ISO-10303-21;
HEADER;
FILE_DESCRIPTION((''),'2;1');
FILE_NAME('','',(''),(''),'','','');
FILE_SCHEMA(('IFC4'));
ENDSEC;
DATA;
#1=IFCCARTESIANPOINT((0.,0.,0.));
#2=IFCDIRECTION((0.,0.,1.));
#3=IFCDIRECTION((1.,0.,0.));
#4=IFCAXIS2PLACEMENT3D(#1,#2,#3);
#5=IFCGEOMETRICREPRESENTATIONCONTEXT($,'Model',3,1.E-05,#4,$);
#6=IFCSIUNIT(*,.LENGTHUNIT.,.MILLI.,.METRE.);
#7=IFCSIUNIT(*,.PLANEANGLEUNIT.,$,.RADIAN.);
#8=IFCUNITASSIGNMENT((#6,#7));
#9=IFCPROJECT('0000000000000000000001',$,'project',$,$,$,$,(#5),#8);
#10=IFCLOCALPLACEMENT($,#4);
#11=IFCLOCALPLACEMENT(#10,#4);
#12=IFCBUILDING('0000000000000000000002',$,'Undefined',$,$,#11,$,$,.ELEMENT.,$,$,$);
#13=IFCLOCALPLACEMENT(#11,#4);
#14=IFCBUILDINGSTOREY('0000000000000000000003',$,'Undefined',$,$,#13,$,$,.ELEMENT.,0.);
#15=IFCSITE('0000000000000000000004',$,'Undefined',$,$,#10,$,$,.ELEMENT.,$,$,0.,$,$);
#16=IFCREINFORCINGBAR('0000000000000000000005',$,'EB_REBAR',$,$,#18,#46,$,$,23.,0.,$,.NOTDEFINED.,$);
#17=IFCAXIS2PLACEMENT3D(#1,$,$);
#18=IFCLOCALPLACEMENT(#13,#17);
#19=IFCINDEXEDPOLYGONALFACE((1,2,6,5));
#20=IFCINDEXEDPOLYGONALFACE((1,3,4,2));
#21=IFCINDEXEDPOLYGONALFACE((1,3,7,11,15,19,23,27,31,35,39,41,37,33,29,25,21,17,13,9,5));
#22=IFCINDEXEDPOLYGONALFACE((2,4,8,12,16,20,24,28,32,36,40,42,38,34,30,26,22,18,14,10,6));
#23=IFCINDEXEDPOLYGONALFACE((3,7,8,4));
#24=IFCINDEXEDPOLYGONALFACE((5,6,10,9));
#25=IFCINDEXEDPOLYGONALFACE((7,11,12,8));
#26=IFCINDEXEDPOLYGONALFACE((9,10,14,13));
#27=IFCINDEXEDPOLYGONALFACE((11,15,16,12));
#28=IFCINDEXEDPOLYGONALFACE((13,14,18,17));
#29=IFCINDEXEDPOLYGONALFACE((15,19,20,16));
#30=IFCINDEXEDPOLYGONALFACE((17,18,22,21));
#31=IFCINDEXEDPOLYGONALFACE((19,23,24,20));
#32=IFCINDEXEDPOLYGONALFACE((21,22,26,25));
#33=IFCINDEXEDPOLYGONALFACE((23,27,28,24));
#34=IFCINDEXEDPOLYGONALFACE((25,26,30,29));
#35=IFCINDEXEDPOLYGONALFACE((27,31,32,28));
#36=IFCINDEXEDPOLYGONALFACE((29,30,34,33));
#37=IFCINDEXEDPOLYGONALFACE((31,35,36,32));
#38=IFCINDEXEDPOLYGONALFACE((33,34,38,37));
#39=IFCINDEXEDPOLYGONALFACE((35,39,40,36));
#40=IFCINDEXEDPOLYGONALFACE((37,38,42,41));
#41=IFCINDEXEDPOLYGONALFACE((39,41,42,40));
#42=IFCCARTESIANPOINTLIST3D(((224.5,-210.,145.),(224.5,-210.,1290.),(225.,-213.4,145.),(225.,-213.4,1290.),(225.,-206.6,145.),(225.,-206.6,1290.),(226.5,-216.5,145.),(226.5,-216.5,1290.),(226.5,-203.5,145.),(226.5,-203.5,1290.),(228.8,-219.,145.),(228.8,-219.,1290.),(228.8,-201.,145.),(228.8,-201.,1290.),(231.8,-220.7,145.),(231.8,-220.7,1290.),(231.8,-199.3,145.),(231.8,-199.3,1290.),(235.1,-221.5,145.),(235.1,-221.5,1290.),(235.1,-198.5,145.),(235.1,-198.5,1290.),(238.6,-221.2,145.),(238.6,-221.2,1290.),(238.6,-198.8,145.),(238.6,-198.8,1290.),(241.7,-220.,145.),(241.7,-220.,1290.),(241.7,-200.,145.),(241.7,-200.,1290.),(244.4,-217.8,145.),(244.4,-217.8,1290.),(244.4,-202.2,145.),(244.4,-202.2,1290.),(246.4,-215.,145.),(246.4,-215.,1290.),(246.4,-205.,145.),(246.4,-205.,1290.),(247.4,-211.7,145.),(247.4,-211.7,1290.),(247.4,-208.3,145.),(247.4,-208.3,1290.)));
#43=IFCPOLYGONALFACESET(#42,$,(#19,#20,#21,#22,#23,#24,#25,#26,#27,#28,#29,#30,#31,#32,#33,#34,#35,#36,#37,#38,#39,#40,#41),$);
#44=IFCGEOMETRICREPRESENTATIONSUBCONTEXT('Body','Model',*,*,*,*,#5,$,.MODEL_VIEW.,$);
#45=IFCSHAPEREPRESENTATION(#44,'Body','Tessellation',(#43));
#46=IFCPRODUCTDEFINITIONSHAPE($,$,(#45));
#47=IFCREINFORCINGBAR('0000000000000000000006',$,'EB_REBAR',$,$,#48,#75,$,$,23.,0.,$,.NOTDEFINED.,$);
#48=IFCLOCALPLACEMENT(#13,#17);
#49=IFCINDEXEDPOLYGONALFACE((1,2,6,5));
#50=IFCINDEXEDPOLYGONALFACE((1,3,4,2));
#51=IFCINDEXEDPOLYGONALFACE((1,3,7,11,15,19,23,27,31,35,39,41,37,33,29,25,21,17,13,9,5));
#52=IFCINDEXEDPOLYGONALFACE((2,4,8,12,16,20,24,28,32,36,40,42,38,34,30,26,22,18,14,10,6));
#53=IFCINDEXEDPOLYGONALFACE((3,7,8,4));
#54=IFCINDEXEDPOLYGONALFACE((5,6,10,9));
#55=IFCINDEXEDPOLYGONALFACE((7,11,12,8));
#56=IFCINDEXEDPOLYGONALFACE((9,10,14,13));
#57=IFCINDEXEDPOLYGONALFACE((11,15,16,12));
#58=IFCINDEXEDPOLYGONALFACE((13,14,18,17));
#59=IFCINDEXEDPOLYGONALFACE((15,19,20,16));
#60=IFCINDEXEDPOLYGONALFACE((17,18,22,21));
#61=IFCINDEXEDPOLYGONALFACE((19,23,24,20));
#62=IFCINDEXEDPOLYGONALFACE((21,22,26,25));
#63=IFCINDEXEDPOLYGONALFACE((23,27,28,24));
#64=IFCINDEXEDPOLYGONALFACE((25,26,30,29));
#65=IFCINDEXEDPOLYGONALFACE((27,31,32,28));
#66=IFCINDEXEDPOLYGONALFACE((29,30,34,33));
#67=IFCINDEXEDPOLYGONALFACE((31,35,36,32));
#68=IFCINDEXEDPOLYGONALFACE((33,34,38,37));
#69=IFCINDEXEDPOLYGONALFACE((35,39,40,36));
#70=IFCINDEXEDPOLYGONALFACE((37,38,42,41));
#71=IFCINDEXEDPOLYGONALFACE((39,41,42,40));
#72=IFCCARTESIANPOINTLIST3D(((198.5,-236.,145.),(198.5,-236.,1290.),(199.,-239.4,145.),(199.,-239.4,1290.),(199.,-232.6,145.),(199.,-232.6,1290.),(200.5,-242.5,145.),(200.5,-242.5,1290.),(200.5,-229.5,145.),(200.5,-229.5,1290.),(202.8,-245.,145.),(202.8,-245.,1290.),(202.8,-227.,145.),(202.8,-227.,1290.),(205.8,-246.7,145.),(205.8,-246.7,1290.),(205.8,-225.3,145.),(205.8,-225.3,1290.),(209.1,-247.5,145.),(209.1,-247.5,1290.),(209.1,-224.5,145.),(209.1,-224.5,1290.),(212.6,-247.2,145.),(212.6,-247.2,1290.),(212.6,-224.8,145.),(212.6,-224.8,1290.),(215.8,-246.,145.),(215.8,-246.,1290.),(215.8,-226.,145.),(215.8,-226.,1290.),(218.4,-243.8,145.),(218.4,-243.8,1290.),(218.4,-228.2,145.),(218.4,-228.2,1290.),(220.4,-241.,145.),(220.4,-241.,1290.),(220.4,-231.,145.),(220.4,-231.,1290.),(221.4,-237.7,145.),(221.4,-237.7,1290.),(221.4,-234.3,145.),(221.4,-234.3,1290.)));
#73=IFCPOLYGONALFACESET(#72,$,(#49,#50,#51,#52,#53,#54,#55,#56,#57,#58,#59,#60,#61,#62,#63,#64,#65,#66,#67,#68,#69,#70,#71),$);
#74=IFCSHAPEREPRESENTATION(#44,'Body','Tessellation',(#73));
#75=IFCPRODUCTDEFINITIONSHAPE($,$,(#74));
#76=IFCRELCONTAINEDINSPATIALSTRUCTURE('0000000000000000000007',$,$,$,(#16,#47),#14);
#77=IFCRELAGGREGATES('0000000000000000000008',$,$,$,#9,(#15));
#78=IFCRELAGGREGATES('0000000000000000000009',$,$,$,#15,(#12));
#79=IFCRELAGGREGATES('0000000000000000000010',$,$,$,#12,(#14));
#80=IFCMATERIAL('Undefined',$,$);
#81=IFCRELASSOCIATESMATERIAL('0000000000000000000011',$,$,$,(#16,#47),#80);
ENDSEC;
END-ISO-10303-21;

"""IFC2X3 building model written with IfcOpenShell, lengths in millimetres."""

from ifc_helpers import new_model, entity, si_unit, frame, origin_with_axes, place, context, subcontext, project, spatial, source, transform, mapped, material, element, save


model = new_model("IFC2X3")

# Units and contexts
model_context = context("Model", 3, precision=1e-05, world=origin_with_axes())
body_context = subcontext(model_context, "Body", "Model", "MODEL_VIEW")
ifc_project = project(units=[si_unit("LENGTHUNIT", "METRE", prefix="MILLI"), si_unit("PLANEANGLEUNIT", "RADIAN")], contexts=[model_context])

# Site, building, storey
site_placement = place(None, origin_with_axes())
site = spatial("IfcSite", under=ifc_project, at=site_placement, Name="Undefined", CompositionType="ELEMENT", RefElevation=0.0)
building_placement = place(site_placement, origin_with_axes())
building = spatial("IfcBuilding", under=site, at=building_placement, Name="Undefined", CompositionType="ELEMENT")
storey_placement = place(building_placement, origin_with_axes())
storey = spatial("IfcBuildingStorey", under=building, at=storey_placement, Name="Undefined", CompositionType="ELEMENT", Elevation=0.0)

# Reinforcing bars
ifc_material_1 = material(Name="Undefined")
shared_shape_1 = source(origin_with_axes(), body_context, "Body", "AdvancedSweptSolid", [
    entity("IfcSweptDiskSolid", entity("IfcTrimmedCurve", entity("IfcLine", entity("IfcCartesianPoint", [0.0, 0.0, 0.0]), entity("IfcVector", entity("IfcDirection", [1.0, 0.0, 0.0]), 1.0)), [entity("IfcParameterValue", 0.0)], [entity("IfcParameterValue", 1144.999881)], True, "PARAMETER"), 11.5, None, 0.0, 1145.0),
])
reinforcing_bar_1_placement = place(storey_placement, frame((236.0, -210.0, 145.0), z_axis=(-1.0, 0.0, 0.0), x_axis=(0.0, 0.0, 1.0)))
element("IfcReinforcingBar", 1, at=reinforcing_bar_1_placement, inside=storey, material=ifc_material_1, Name="EB_REBAR", BarRole="NOTDEFINED", CrossSectionArea=0.0, NominalDiameter=23.0, context=body_context, shape_type="MappedRepresentation", body=[
    mapped(shared_shape_1, transform((0.0, 0.0, 0.0))),
])
shared_shape_2 = source(origin_with_axes(), body_context, "Body", "AdvancedSweptSolid", [
    entity("IfcSweptDiskSolid", entity("IfcTrimmedCurve", entity("IfcLine", entity("IfcCartesianPoint", [0.0, 0.0, 0.0]), entity("IfcVector", entity("IfcDirection", [1.0, 0.0, 0.0]), 1.0)), [entity("IfcParameterValue", 0.0)], [entity("IfcParameterValue", 1144.999996)], True, "PARAMETER"), 11.5, None, 0.0, 1145.0),
])
reinforcing_bar_2_placement = place(storey_placement, frame((210.0, -236.0, 145.0), z_axis=(-1.0, 0.0, 0.0), x_axis=(0.0, 0.0, 1.0)))
element("IfcReinforcingBar", 2, at=reinforcing_bar_2_placement, inside=storey, material=ifc_material_1, Name="EB_REBAR", BarRole="NOTDEFINED", CrossSectionArea=0.0, NominalDiameter=23.0, context=body_context, shape_type="MappedRepresentation", body=[
    mapped(shared_shape_2, transform((0.0, 0.0, 0.0))),
])

save(model, "model.ifc")
